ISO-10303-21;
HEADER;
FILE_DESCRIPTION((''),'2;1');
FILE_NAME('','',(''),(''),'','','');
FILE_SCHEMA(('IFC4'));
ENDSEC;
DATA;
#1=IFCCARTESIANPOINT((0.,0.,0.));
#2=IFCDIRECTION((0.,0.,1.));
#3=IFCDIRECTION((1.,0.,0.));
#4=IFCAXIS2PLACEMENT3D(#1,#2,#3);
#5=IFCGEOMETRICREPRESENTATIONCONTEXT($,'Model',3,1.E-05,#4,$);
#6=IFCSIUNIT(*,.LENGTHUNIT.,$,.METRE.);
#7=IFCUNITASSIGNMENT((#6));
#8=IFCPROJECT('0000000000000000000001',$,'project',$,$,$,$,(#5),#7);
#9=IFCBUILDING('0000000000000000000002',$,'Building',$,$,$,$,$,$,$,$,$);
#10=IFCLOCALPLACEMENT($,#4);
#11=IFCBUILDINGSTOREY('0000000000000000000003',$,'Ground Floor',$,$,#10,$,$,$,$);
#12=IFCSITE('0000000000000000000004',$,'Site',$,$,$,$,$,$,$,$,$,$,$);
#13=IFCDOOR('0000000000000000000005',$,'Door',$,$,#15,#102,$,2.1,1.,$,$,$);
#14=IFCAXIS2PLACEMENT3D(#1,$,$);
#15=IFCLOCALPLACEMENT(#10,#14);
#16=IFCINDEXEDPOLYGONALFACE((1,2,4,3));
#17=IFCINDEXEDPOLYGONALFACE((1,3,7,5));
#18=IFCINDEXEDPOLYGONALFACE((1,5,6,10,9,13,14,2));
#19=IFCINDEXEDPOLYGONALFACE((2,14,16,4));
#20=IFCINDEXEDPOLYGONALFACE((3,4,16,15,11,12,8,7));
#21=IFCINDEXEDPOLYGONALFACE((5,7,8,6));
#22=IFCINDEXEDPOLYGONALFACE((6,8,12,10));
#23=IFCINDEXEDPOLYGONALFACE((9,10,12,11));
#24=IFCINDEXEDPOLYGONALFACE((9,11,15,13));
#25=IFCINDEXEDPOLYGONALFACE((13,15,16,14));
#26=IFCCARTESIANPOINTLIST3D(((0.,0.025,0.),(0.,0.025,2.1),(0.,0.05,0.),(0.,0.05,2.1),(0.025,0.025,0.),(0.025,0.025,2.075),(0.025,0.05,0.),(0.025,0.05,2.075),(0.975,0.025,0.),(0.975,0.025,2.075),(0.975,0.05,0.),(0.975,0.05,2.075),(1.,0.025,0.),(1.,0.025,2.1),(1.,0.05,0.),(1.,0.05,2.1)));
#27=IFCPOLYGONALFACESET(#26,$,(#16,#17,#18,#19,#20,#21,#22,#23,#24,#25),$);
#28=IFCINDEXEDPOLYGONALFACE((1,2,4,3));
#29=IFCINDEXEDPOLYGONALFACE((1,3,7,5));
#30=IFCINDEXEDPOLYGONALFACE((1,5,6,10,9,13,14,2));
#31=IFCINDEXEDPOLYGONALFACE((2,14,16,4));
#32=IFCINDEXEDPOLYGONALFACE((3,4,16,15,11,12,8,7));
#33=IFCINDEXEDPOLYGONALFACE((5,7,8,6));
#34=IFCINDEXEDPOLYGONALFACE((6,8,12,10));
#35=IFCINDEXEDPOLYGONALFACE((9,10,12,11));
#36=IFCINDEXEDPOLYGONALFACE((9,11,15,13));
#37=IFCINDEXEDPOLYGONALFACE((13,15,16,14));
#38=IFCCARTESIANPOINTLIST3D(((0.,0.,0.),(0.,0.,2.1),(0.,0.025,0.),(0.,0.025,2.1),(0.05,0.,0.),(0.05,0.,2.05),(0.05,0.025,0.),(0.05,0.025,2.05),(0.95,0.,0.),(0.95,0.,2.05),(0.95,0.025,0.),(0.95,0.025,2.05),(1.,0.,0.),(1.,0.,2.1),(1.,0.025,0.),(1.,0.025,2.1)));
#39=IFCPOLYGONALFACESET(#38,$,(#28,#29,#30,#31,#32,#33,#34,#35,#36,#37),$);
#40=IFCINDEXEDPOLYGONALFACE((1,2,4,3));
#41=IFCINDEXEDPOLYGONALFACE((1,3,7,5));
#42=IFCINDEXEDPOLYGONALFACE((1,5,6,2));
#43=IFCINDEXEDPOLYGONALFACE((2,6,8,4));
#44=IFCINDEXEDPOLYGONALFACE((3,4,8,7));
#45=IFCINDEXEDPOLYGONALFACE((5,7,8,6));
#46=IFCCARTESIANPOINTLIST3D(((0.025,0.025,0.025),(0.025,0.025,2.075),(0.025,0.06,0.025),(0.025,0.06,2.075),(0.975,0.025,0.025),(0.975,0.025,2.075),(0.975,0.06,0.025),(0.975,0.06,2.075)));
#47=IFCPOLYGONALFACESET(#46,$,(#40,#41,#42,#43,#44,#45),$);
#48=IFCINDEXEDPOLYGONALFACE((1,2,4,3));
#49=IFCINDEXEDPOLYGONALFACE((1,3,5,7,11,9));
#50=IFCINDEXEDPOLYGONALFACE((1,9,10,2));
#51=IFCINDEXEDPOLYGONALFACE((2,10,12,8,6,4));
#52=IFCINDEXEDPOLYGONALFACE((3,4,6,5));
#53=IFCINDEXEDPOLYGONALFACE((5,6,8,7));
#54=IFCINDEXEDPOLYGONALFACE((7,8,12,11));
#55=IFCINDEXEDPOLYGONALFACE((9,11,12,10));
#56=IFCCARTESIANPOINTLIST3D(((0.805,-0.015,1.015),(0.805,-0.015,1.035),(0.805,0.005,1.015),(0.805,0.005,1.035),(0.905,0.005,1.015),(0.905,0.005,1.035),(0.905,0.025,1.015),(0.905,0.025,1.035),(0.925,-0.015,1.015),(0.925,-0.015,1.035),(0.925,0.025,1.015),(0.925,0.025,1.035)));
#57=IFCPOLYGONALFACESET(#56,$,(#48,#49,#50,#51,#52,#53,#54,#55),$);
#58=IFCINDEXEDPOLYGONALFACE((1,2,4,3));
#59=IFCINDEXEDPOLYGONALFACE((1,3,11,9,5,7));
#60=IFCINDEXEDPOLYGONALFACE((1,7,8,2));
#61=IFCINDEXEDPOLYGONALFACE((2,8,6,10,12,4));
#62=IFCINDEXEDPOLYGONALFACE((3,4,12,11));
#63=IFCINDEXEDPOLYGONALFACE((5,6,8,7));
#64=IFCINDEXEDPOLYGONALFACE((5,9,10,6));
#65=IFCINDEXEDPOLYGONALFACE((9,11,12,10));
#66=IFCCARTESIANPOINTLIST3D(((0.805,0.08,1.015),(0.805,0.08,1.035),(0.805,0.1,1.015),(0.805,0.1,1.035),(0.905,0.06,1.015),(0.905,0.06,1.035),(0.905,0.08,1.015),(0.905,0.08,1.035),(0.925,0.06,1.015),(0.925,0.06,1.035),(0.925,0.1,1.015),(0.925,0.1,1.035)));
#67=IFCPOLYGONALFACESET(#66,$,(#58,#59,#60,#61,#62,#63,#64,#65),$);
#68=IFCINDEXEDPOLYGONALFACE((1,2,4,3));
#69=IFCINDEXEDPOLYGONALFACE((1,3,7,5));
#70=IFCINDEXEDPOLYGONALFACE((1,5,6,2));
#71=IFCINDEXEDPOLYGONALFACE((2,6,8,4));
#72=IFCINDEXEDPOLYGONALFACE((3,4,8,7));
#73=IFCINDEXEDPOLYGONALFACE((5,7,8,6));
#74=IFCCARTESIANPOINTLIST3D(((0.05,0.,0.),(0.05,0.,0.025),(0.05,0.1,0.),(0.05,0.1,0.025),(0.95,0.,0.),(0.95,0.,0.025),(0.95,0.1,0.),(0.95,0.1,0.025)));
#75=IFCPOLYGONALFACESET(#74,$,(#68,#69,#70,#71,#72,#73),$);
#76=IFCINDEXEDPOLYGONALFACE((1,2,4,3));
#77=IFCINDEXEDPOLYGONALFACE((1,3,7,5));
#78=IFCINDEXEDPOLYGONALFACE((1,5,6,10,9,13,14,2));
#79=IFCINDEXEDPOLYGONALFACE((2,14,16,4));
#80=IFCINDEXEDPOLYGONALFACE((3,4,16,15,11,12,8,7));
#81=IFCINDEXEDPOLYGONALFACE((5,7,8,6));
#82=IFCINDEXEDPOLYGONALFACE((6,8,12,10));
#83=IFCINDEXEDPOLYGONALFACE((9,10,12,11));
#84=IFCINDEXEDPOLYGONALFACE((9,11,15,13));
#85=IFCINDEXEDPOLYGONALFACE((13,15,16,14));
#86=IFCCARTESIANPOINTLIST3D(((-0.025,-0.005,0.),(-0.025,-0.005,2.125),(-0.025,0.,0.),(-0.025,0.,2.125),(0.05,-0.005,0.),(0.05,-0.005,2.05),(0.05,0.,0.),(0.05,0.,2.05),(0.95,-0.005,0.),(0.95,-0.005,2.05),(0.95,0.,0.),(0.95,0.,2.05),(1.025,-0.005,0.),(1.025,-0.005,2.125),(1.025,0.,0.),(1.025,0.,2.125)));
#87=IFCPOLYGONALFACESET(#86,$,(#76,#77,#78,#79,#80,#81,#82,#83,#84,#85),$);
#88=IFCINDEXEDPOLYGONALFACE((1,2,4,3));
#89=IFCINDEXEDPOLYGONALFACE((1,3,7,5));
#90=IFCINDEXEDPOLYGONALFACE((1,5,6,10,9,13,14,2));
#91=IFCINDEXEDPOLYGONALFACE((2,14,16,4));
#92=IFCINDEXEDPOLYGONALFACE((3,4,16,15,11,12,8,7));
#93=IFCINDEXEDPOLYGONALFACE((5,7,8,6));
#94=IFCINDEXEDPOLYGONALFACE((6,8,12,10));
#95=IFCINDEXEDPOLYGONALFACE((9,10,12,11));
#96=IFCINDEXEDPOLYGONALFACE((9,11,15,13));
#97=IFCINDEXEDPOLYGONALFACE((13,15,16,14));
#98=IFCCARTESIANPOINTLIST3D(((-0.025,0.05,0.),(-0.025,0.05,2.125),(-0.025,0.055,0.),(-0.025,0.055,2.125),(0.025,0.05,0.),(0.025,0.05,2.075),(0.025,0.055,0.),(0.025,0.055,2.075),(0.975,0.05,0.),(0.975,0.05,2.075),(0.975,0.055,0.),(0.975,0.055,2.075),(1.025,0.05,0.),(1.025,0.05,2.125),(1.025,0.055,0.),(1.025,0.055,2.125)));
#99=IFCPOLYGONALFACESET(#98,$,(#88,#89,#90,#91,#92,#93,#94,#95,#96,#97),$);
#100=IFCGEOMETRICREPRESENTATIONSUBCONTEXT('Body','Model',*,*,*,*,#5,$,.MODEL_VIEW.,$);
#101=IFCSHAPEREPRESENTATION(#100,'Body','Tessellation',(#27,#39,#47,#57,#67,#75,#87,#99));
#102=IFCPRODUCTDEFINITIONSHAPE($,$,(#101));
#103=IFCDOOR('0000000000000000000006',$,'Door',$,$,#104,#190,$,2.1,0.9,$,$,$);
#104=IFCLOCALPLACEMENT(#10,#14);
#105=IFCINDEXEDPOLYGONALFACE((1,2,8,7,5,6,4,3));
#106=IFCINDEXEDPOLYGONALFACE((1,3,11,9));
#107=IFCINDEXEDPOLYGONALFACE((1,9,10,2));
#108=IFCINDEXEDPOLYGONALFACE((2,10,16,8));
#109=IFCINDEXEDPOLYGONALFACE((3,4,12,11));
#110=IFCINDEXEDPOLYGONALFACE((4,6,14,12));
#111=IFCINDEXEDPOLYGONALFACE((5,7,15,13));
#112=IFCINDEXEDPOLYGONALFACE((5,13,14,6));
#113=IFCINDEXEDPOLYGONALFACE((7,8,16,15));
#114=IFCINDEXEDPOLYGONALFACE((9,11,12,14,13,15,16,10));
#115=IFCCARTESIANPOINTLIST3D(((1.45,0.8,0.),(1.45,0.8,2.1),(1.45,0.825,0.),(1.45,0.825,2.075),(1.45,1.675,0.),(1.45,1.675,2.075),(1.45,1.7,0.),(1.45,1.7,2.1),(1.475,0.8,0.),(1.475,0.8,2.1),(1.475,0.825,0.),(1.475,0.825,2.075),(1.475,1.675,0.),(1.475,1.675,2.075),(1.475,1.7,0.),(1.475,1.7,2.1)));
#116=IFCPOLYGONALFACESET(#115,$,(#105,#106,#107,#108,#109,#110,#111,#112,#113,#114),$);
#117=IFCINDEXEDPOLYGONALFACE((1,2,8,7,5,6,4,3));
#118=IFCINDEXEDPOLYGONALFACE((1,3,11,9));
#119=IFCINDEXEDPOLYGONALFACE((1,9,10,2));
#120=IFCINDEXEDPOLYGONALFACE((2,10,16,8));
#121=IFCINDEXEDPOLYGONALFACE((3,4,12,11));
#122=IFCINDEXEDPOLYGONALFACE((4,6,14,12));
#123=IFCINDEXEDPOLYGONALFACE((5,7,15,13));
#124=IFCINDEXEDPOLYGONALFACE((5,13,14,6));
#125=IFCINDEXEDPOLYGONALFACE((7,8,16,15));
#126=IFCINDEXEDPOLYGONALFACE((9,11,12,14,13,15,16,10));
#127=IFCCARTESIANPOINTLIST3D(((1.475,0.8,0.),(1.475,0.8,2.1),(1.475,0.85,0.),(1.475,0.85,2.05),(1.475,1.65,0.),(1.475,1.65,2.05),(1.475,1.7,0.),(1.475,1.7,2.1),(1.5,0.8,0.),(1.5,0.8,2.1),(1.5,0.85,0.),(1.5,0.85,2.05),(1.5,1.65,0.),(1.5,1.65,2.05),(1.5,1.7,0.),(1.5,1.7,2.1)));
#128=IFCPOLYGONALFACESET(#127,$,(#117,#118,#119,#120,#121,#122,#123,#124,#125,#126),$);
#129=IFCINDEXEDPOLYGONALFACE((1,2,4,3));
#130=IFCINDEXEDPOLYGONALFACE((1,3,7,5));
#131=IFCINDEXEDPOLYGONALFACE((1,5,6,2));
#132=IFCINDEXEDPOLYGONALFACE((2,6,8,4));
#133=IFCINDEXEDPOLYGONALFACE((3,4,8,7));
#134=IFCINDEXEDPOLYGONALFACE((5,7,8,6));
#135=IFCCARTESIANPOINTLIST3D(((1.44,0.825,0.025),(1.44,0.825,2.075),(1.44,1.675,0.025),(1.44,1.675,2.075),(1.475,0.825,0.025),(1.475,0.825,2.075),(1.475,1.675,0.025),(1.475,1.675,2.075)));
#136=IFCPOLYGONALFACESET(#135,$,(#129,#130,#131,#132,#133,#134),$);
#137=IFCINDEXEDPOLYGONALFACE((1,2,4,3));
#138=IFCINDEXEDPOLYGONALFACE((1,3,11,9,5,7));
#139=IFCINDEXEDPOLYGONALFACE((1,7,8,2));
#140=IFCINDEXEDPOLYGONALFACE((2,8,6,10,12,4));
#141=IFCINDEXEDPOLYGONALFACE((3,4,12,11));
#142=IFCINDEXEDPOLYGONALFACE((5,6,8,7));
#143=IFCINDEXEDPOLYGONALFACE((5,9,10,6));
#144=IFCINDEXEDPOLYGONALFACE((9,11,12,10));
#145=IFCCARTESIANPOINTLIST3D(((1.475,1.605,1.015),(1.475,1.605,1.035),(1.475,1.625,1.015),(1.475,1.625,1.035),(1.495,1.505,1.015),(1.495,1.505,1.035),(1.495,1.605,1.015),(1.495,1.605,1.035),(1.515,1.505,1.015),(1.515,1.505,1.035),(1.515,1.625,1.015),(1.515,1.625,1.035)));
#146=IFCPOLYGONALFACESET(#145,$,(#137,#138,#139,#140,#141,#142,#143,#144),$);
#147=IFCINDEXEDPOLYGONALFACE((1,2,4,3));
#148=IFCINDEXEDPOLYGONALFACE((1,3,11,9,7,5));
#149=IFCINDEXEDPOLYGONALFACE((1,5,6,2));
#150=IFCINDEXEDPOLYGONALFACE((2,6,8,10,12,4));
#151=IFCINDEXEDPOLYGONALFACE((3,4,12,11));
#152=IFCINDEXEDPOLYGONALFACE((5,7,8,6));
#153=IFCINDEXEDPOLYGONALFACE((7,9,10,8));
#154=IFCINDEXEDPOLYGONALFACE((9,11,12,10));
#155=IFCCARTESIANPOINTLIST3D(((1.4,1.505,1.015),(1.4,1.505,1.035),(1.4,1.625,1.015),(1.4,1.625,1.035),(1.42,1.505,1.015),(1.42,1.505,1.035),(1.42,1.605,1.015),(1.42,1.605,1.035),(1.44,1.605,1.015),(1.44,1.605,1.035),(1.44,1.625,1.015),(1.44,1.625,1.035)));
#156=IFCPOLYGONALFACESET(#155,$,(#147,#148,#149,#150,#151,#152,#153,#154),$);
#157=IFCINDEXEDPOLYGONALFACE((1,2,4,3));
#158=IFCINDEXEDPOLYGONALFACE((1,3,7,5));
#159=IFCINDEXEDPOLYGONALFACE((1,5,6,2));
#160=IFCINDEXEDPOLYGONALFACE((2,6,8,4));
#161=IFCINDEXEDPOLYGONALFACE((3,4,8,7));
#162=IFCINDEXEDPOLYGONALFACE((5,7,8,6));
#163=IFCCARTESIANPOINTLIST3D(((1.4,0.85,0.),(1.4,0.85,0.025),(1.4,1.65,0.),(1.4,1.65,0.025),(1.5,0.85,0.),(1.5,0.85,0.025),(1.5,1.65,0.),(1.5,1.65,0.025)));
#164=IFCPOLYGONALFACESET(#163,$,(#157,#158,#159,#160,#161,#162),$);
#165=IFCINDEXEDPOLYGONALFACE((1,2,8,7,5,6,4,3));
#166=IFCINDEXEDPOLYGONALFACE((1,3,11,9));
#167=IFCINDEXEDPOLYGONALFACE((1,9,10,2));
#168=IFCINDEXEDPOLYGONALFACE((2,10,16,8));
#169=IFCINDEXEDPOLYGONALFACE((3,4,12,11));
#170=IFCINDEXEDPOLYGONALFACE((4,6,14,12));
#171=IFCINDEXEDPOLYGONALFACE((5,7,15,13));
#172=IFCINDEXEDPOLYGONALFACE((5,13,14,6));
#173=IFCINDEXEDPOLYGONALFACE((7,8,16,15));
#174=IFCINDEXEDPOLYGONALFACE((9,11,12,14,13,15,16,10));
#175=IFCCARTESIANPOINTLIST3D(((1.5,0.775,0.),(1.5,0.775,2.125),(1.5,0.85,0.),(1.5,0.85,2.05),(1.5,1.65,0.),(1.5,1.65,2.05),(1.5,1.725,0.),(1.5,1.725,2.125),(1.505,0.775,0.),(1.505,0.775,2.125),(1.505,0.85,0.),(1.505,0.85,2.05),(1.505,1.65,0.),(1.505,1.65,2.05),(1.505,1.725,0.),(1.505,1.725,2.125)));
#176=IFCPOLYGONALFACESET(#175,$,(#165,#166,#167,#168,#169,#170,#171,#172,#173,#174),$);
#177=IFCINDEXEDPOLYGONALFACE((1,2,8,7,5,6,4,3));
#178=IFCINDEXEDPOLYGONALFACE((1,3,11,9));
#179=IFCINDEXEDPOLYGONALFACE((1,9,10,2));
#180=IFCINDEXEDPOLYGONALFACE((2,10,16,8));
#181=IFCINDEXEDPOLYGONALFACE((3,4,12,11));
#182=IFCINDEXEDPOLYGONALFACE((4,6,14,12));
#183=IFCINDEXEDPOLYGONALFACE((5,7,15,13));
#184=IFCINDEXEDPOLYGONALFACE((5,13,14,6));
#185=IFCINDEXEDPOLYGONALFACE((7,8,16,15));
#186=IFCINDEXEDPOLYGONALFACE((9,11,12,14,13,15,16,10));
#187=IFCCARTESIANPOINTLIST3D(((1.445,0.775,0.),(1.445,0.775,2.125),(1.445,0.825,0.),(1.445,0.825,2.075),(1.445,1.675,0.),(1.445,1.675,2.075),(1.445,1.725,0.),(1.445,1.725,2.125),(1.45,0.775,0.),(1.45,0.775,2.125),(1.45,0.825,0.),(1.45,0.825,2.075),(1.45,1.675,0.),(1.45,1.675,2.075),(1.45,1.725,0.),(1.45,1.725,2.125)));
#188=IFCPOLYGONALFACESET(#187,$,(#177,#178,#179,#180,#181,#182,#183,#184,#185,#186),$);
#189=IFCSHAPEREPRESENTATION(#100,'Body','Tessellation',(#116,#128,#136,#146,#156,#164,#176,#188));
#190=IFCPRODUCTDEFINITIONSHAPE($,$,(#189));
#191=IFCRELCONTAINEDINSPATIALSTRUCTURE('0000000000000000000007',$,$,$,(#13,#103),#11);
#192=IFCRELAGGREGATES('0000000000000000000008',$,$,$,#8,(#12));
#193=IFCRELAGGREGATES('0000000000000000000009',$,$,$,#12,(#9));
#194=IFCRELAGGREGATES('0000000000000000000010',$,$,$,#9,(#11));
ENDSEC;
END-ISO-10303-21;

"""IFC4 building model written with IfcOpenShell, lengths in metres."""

from ifc_helpers import new_model, si_unit, frame, origin_with_axes, place, context, subcontext, project, spatial, line, indexed_curve, outline, extrude, element, save


model = new_model("IFC4")

# Units and contexts
model_context = context("Model", 3, precision=1e-05, world=origin_with_axes())
body_context = subcontext(model_context, "Body", "Model", "MODEL_VIEW")
ifc_project = project(units=[si_unit("LENGTHUNIT", "METRE")], contexts=[model_context])

# Site, building, storey
site = spatial("IfcSite", under=ifc_project, Name="Site")
building = spatial("IfcBuilding", under=site, Name="Building")
storey_placement = place(None, origin_with_axes())
storey = spatial("IfcBuildingStorey", under=building, at=storey_placement, Name="Ground Floor")

# Doors
door_1_placement = place(storey_placement, origin_with_axes())
element("IfcDoor", 1, at=door_1_placement, inside=storey, Name="Door", OverallHeight=2.1, OverallWidth=1.0, context=body_context, shape_type="SweptSolid", body=[
    extrude(outline(indexed_curve([(0.0, 0.0), (0.0, 2.1), (1.0, 2.1), (1.0, 0.0), (0.975, 0.0), (0.975, 2.075), (0.025, 2.075), (0.025, 0.0)], segments=[line(1, 2, 3, 4, 5, 6, 7, 8, 1)])), frame((0.0, 0.025, 0.0), z_axis=(0.0, -1.0, 0.0), x_axis=(1.0, 0.0, 0.0)), (0.0, 0.0, -1.0), 0.025),
    extrude(outline(indexed_curve([(0.0, 0.0), (0.0, 2.1), (1.0, 2.1), (1.0, 0.0), (0.95, 0.0), (0.95, 2.05), (0.05, 2.05), (0.05, 0.0)], segments=[line(1, 2, 3, 4, 5, 6, 7, 8, 1)])), frame((0.0, 0.0, 0.0), z_axis=(0.0, -1.0, 0.0), x_axis=(1.0, 0.0, 0.0)), (0.0, 0.0, -1.0), 0.025),
    extrude(outline(indexed_curve([(0.0, 0.0), (0.95, 0.0), (0.95, 0.035), (0.0, 0.035)], segments=[line(1, 2, 3, 4, 1)])), frame((0.025, 0.025, 0.025), z_axis=(0.0, 0.0, 1.0), x_axis=(1.0, 0.0, 0.0)), (0.0, 0.0, 1.0), 2.05),
    extrude(outline(indexed_curve([(0.0, 0.0), (0.0, -0.04), (-0.12, -0.04), (-0.12, -0.02), (-0.02, -0.02), (-0.02, 0.0)], segments=[line(1, 2, 3, 4, 5, 6, 1)])), frame((0.925, 0.025, 1.015), z_axis=(0.0, 0.0, 1.0), x_axis=(1.0, 0.0, 0.0)), (0.0, 0.0, 1.0), 0.02),
    extrude(outline(indexed_curve([(0.0, 0.0), (0.0, 0.04), (-0.12, 0.04), (-0.12, 0.02), (-0.02, 0.02), (-0.02, 0.0)], segments=[line(1, 2, 3, 4, 5, 6, 1)])), frame((0.925, 0.06, 1.015), z_axis=(0.0, 0.0, 1.0), x_axis=(1.0, 0.0, 0.0)), (0.0, 0.0, 1.0), 0.02),
    extrude(outline(indexed_curve([(0.0, 0.0), (0.9, 0.0), (0.9, 0.1), (0.0, 0.1)], segments=[line(1, 2, 3, 4, 1)])), frame((0.05, 0.0, 0.0), z_axis=(0.0, 0.0, 1.0), x_axis=(1.0, 0.0, 0.0)), (0.0, 0.0, 1.0), 0.025),
    extrude(outline(indexed_curve([(0.0, 0.0), (0.0, 2.125), (1.05, 2.125), (1.05, 0.0), (0.975, 0.0), (0.975, 2.05), (0.075, 2.05), (0.075, 0.0)], segments=[line(1, 2, 3, 4, 5, 6, 7, 8, 1)])), frame((-0.025, -0.005, 0.0), z_axis=(0.0, -1.0, 0.0), x_axis=(1.0, 0.0, 0.0)), (0.0, 0.0, -1.0), 0.005),
    extrude(outline(indexed_curve([(0.0, 0.0), (0.0, 2.125), (1.05, 2.125), (1.05, 0.0), (1.0, 0.0), (1.0, 2.075), (0.05, 2.075), (0.05, 0.0)], segments=[line(1, 2, 3, 4, 5, 6, 7, 8, 1)])), frame((-0.025, 0.05, 0.0), z_axis=(0.0, -1.0, 0.0), x_axis=(1.0, 0.0, 0.0)), (0.0, 0.0, -1.0), 0.005),
])
door_2_placement = place(storey_placement, frame((1.5, 0.8, 0.0), z_axis=(0.0, 0.0, 1.0), x_axis=(0.0, 1.0, 0.0)))
element("IfcDoor", 2, at=door_2_placement, inside=storey, Name="Door", OverallHeight=2.1, OverallWidth=0.9, context=body_context, shape_type="SweptSolid", body=[
    extrude(outline(indexed_curve([(0.0, 0.0), (0.0, 2.1), (0.9, 2.1), (0.9, 0.0), (0.875, 0.0), (0.875, 2.075), (0.025, 2.075), (0.025, 0.0)], segments=[line(1, 2, 3, 4, 5, 6, 7, 8, 1)])), frame((0.0, 0.025, 0.0), z_axis=(0.0, -1.0, 0.0), x_axis=(1.0, 0.0, 0.0)), (0.0, 0.0, -1.0), 0.025),
    extrude(outline(indexed_curve([(0.0, 0.0), (0.0, 2.1), (0.9, 2.1), (0.9, 0.0), (0.85, 0.0), (0.85, 2.05), (0.05, 2.05), (0.05, 0.0)], segments=[line(1, 2, 3, 4, 5, 6, 7, 8, 1)])), frame((0.0, 0.0, 0.0), z_axis=(0.0, -1.0, 0.0), x_axis=(1.0, 0.0, 0.0)), (0.0, 0.0, -1.0), 0.025),
    extrude(outline(indexed_curve([(0.0, 0.0), (0.85, 0.0), (0.85, 0.035), (0.0, 0.035)], segments=[line(1, 2, 3, 4, 1)])), frame((0.025, 0.025, 0.025), z_axis=(0.0, 0.0, 1.0), x_axis=(1.0, 0.0, 0.0)), (0.0, 0.0, 1.0), 2.05),
    extrude(outline(indexed_curve([(0.0, 0.0), (0.0, -0.04), (-0.12, -0.04), (-0.12, -0.02), (-0.02, -0.02), (-0.02, 0.0)], segments=[line(1, 2, 3, 4, 5, 6, 1)])), frame((0.825, 0.025, 1.015), z_axis=(0.0, 0.0, 1.0), x_axis=(1.0, 0.0, 0.0)), (0.0, 0.0, 1.0), 0.02),
    extrude(outline(indexed_curve([(0.0, 0.0), (0.0, 0.04), (-0.12, 0.04), (-0.12, 0.02), (-0.02, 0.02), (-0.02, 0.0)], segments=[line(1, 2, 3, 4, 5, 6, 1)])), frame((0.825, 0.06, 1.015), z_axis=(0.0, 0.0, 1.0), x_axis=(1.0, 0.0, 0.0)), (0.0, 0.0, 1.0), 0.02),
    extrude(outline(indexed_curve([(0.0, 0.0), (0.8, 0.0), (0.8, 0.1), (0.0, 0.1)], segments=[line(1, 2, 3, 4, 1)])), frame((0.05, 0.0, 0.0), z_axis=(0.0, 0.0, 1.0), x_axis=(1.0, 0.0, 0.0)), (0.0, 0.0, 1.0), 0.025),
    extrude(outline(indexed_curve([(0.0, 0.0), (0.0, 2.125), (0.95, 2.125), (0.95, 0.0), (0.875, 0.0), (0.875, 2.05), (0.075, 2.05), (0.075, 0.0)], segments=[line(1, 2, 3, 4, 5, 6, 7, 8, 1)])), frame((-0.025, -0.005, 0.0), z_axis=(0.0, -1.0, 0.0), x_axis=(1.0, 0.0, 0.0)), (0.0, 0.0, -1.0), 0.005),
    extrude(outline(indexed_curve([(0.0, 0.0), (0.0, 2.125), (0.95, 2.125), (0.95, 0.0), (0.9, 0.0), (0.9, 2.075), (0.05, 2.075), (0.05, 0.0)], segments=[line(1, 2, 3, 4, 5, 6, 7, 8, 1)])), frame((-0.025, 0.05, 0.0), z_axis=(0.0, -1.0, 0.0), x_axis=(1.0, 0.0, 0.0)), (0.0, 0.0, -1.0), 0.005),
])

save(model, "model.ifc")
